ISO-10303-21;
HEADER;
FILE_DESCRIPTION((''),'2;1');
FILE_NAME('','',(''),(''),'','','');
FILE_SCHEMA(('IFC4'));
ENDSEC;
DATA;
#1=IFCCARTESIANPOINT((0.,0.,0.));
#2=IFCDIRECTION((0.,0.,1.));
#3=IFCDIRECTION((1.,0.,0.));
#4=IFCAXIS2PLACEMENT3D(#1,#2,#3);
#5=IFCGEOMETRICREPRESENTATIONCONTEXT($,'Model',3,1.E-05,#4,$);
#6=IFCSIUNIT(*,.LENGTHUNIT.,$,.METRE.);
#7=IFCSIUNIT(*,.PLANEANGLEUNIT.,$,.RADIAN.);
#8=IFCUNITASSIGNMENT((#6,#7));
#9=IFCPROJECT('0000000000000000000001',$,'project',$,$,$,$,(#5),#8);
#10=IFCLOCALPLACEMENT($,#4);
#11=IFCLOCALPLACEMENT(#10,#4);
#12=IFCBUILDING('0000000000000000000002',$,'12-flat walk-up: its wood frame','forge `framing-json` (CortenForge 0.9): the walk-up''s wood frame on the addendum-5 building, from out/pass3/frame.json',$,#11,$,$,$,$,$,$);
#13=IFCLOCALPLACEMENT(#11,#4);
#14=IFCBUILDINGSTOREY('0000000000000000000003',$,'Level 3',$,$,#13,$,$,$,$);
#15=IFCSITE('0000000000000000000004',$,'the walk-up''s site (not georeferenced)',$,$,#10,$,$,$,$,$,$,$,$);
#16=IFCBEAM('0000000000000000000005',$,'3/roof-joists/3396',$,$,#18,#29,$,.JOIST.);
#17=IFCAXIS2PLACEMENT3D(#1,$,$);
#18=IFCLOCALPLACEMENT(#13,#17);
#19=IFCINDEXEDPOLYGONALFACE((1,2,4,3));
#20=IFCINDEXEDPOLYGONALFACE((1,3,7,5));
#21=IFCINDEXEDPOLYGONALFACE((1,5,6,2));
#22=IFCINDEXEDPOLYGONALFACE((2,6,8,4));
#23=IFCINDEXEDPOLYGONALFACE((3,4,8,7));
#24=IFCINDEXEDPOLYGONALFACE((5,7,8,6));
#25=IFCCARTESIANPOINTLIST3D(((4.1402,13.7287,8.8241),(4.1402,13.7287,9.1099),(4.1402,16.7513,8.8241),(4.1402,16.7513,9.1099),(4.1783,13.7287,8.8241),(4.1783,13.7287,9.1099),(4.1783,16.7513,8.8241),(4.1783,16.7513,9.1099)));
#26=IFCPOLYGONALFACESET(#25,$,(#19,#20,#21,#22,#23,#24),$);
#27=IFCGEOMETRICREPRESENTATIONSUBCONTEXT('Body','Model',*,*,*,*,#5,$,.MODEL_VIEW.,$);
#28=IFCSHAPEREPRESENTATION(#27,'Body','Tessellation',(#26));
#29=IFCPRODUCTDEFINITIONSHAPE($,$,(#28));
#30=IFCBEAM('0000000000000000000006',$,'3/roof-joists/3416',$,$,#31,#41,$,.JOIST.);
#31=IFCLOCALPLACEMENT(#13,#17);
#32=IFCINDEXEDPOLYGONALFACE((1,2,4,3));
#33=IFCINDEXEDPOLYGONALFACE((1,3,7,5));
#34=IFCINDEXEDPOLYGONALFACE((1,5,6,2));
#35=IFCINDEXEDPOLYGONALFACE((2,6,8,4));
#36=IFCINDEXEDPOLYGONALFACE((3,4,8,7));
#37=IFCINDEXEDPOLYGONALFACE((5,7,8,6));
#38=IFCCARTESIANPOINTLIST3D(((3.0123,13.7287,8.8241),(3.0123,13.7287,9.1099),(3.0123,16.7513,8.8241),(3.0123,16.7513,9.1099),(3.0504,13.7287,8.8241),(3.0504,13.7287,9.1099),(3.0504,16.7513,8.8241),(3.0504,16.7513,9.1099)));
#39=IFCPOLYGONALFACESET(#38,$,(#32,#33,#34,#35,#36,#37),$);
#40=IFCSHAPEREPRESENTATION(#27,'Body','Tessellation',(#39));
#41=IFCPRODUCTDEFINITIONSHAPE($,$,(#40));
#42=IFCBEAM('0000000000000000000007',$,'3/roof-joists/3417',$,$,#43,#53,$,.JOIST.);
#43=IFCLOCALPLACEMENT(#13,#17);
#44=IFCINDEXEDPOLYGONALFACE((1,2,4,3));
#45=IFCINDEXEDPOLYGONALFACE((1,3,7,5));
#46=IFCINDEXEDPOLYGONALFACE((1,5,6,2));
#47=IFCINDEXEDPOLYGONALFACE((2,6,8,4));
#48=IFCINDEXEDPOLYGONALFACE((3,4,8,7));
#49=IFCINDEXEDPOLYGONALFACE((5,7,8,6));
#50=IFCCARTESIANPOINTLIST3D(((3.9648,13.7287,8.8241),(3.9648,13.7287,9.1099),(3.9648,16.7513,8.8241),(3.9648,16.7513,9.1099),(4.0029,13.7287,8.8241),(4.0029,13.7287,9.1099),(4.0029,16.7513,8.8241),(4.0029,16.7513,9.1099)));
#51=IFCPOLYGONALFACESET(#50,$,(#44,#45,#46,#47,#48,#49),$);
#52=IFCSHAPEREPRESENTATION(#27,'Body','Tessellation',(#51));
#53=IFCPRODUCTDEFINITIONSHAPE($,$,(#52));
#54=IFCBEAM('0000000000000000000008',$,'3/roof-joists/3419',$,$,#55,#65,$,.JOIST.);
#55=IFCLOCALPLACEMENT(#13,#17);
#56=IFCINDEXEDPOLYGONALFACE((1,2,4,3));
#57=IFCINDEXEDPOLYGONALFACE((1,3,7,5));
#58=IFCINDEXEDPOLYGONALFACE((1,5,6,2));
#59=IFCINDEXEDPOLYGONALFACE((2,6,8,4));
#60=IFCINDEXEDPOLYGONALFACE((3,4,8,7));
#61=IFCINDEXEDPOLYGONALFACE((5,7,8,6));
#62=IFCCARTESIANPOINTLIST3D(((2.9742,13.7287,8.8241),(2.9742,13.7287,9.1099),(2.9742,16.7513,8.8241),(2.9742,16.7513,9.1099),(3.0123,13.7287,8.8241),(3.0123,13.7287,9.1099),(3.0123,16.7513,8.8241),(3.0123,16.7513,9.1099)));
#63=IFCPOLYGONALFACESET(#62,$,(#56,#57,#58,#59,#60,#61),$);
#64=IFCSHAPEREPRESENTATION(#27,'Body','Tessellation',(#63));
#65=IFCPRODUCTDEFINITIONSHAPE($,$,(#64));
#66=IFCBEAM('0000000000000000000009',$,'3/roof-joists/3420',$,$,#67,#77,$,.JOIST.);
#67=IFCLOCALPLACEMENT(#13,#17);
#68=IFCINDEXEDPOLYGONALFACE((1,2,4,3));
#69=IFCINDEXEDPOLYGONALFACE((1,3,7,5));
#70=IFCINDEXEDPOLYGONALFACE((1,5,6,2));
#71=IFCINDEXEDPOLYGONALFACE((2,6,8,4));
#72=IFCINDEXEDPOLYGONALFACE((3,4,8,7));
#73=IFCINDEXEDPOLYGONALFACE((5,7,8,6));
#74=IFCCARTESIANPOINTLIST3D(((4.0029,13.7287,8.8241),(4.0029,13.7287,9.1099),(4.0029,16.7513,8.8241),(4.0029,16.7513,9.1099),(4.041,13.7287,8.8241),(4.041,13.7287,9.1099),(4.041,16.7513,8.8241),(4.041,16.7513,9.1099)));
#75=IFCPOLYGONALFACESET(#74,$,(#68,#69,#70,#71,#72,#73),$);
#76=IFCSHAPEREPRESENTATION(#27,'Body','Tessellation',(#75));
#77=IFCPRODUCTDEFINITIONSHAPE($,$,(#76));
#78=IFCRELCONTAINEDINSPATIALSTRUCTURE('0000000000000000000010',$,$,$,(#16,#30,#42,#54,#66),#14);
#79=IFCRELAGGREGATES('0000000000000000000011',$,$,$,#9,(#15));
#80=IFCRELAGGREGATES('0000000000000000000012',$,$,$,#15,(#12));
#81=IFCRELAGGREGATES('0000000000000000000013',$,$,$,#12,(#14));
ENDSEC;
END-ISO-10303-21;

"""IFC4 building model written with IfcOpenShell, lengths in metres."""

from ifc_helpers import new_model, si_unit, frame, frame_2d, origin, origin_with_axes, place, context, subcontext, project, spatial, rectangle, extrude, element, save


model = new_model("IFC4")

# Units and contexts
model_context = context("Model", 3, precision=1e-05, world=origin_with_axes())
body_context = subcontext(model_context, "Body", "Model", "MODEL_VIEW")
ifc_project = project(units=[si_unit("LENGTHUNIT", "METRE"), si_unit("PLANEANGLEUNIT", "RADIAN")], contexts=[model_context])

# Site, building, storey
site_placement = place(None, origin_with_axes())
site = spatial("IfcSite", under=ifc_project, at=site_placement, Name="the walk-up's site (not georeferenced)")
building_placement = place(site_placement, origin_with_axes())
building = spatial("IfcBuilding", under=site, at=building_placement, Name="12-flat walk-up: its wood frame", Description="forge `framing-json` (CortenForge 0.9): the walk-up's wood frame on the addendum-5 building, from out/pass3/frame.json")
storey_placement = place(building_placement, origin_with_axes())
storey = spatial("IfcBuildingStorey", under=building, at=storey_placement, Name="Level 3")

# Beams
for number, where, z_axis, x_axis, name in (
    (1, (4.1402, 13.7287, 8.8241), (0.0, 0.0, 1.0), (1.0, 0.0, 0.0), "3/roof-joists/3396"),
):
    element("IfcBeam", number, at=place(storey_placement, frame(where, z_axis=z_axis, x_axis=x_axis)), inside=storey, Name=name, PredefinedType="JOIST", context=body_context, shape_type="SweptSolid", body=[
        extrude(rectangle(XDim=0.0381, YDim=3.0226, at=frame_2d((0.0191, 1.5113))), origin(), (0.0, 0.0, 1.0), 0.2858),
    ])
beam_1_placement = place(storey_placement, frame((3.0123, 13.7287, 8.8241), z_axis=(0.0, 0.0, 1.0), x_axis=(1.0, 0.0, 0.0)))
element("IfcBeam", 2, at=beam_1_placement, inside=storey, Name="3/roof-joists/3416", PredefinedType="JOIST", context=body_context, shape_type="SweptSolid", body=[
    extrude(rectangle(XDim=0.0381, YDim=3.0226, at=frame_2d((0.019, 1.5113))), origin(), (0.0, 0.0, 1.0), 0.2858),
])
beam_2_placement = place(storey_placement, frame((3.9648, 13.7287, 8.8241), z_axis=(0.0, 0.0, 1.0), x_axis=(1.0, 0.0, 0.0)))
element("IfcBeam", 3, at=beam_2_placement, inside=storey, Name="3/roof-joists/3417", PredefinedType="JOIST", context=body_context, shape_type="SweptSolid", body=[
    extrude(rectangle(XDim=0.0381, YDim=3.0226, at=frame_2d((0.0191, 1.5113))), origin(), (0.0, 0.0, 1.0), 0.2858),
])
for number, where, z_axis, x_axis, name in (
    (4, (2.9742, 13.7287, 8.8241), (0.0, 0.0, 1.0), (1.0, 0.0, 0.0), "3/roof-joists/3419"),
    (5, (4.0029, 13.7287, 8.8241), (0.0, 0.0, 1.0), (1.0, 0.0, 0.0), "3/roof-joists/3420"),
):
    element("IfcBeam", number, at=place(storey_placement, frame(where, z_axis=z_axis, x_axis=x_axis)), inside=storey, Name=name, PredefinedType="JOIST", context=body_context, shape_type="SweptSolid", body=[
        extrude(rectangle(XDim=0.0381, YDim=3.0226, at=frame_2d((0.0191, 1.5113))), origin(), (0.0, 0.0, 1.0), 0.2858),
    ])

save(model, "model.ifc")
